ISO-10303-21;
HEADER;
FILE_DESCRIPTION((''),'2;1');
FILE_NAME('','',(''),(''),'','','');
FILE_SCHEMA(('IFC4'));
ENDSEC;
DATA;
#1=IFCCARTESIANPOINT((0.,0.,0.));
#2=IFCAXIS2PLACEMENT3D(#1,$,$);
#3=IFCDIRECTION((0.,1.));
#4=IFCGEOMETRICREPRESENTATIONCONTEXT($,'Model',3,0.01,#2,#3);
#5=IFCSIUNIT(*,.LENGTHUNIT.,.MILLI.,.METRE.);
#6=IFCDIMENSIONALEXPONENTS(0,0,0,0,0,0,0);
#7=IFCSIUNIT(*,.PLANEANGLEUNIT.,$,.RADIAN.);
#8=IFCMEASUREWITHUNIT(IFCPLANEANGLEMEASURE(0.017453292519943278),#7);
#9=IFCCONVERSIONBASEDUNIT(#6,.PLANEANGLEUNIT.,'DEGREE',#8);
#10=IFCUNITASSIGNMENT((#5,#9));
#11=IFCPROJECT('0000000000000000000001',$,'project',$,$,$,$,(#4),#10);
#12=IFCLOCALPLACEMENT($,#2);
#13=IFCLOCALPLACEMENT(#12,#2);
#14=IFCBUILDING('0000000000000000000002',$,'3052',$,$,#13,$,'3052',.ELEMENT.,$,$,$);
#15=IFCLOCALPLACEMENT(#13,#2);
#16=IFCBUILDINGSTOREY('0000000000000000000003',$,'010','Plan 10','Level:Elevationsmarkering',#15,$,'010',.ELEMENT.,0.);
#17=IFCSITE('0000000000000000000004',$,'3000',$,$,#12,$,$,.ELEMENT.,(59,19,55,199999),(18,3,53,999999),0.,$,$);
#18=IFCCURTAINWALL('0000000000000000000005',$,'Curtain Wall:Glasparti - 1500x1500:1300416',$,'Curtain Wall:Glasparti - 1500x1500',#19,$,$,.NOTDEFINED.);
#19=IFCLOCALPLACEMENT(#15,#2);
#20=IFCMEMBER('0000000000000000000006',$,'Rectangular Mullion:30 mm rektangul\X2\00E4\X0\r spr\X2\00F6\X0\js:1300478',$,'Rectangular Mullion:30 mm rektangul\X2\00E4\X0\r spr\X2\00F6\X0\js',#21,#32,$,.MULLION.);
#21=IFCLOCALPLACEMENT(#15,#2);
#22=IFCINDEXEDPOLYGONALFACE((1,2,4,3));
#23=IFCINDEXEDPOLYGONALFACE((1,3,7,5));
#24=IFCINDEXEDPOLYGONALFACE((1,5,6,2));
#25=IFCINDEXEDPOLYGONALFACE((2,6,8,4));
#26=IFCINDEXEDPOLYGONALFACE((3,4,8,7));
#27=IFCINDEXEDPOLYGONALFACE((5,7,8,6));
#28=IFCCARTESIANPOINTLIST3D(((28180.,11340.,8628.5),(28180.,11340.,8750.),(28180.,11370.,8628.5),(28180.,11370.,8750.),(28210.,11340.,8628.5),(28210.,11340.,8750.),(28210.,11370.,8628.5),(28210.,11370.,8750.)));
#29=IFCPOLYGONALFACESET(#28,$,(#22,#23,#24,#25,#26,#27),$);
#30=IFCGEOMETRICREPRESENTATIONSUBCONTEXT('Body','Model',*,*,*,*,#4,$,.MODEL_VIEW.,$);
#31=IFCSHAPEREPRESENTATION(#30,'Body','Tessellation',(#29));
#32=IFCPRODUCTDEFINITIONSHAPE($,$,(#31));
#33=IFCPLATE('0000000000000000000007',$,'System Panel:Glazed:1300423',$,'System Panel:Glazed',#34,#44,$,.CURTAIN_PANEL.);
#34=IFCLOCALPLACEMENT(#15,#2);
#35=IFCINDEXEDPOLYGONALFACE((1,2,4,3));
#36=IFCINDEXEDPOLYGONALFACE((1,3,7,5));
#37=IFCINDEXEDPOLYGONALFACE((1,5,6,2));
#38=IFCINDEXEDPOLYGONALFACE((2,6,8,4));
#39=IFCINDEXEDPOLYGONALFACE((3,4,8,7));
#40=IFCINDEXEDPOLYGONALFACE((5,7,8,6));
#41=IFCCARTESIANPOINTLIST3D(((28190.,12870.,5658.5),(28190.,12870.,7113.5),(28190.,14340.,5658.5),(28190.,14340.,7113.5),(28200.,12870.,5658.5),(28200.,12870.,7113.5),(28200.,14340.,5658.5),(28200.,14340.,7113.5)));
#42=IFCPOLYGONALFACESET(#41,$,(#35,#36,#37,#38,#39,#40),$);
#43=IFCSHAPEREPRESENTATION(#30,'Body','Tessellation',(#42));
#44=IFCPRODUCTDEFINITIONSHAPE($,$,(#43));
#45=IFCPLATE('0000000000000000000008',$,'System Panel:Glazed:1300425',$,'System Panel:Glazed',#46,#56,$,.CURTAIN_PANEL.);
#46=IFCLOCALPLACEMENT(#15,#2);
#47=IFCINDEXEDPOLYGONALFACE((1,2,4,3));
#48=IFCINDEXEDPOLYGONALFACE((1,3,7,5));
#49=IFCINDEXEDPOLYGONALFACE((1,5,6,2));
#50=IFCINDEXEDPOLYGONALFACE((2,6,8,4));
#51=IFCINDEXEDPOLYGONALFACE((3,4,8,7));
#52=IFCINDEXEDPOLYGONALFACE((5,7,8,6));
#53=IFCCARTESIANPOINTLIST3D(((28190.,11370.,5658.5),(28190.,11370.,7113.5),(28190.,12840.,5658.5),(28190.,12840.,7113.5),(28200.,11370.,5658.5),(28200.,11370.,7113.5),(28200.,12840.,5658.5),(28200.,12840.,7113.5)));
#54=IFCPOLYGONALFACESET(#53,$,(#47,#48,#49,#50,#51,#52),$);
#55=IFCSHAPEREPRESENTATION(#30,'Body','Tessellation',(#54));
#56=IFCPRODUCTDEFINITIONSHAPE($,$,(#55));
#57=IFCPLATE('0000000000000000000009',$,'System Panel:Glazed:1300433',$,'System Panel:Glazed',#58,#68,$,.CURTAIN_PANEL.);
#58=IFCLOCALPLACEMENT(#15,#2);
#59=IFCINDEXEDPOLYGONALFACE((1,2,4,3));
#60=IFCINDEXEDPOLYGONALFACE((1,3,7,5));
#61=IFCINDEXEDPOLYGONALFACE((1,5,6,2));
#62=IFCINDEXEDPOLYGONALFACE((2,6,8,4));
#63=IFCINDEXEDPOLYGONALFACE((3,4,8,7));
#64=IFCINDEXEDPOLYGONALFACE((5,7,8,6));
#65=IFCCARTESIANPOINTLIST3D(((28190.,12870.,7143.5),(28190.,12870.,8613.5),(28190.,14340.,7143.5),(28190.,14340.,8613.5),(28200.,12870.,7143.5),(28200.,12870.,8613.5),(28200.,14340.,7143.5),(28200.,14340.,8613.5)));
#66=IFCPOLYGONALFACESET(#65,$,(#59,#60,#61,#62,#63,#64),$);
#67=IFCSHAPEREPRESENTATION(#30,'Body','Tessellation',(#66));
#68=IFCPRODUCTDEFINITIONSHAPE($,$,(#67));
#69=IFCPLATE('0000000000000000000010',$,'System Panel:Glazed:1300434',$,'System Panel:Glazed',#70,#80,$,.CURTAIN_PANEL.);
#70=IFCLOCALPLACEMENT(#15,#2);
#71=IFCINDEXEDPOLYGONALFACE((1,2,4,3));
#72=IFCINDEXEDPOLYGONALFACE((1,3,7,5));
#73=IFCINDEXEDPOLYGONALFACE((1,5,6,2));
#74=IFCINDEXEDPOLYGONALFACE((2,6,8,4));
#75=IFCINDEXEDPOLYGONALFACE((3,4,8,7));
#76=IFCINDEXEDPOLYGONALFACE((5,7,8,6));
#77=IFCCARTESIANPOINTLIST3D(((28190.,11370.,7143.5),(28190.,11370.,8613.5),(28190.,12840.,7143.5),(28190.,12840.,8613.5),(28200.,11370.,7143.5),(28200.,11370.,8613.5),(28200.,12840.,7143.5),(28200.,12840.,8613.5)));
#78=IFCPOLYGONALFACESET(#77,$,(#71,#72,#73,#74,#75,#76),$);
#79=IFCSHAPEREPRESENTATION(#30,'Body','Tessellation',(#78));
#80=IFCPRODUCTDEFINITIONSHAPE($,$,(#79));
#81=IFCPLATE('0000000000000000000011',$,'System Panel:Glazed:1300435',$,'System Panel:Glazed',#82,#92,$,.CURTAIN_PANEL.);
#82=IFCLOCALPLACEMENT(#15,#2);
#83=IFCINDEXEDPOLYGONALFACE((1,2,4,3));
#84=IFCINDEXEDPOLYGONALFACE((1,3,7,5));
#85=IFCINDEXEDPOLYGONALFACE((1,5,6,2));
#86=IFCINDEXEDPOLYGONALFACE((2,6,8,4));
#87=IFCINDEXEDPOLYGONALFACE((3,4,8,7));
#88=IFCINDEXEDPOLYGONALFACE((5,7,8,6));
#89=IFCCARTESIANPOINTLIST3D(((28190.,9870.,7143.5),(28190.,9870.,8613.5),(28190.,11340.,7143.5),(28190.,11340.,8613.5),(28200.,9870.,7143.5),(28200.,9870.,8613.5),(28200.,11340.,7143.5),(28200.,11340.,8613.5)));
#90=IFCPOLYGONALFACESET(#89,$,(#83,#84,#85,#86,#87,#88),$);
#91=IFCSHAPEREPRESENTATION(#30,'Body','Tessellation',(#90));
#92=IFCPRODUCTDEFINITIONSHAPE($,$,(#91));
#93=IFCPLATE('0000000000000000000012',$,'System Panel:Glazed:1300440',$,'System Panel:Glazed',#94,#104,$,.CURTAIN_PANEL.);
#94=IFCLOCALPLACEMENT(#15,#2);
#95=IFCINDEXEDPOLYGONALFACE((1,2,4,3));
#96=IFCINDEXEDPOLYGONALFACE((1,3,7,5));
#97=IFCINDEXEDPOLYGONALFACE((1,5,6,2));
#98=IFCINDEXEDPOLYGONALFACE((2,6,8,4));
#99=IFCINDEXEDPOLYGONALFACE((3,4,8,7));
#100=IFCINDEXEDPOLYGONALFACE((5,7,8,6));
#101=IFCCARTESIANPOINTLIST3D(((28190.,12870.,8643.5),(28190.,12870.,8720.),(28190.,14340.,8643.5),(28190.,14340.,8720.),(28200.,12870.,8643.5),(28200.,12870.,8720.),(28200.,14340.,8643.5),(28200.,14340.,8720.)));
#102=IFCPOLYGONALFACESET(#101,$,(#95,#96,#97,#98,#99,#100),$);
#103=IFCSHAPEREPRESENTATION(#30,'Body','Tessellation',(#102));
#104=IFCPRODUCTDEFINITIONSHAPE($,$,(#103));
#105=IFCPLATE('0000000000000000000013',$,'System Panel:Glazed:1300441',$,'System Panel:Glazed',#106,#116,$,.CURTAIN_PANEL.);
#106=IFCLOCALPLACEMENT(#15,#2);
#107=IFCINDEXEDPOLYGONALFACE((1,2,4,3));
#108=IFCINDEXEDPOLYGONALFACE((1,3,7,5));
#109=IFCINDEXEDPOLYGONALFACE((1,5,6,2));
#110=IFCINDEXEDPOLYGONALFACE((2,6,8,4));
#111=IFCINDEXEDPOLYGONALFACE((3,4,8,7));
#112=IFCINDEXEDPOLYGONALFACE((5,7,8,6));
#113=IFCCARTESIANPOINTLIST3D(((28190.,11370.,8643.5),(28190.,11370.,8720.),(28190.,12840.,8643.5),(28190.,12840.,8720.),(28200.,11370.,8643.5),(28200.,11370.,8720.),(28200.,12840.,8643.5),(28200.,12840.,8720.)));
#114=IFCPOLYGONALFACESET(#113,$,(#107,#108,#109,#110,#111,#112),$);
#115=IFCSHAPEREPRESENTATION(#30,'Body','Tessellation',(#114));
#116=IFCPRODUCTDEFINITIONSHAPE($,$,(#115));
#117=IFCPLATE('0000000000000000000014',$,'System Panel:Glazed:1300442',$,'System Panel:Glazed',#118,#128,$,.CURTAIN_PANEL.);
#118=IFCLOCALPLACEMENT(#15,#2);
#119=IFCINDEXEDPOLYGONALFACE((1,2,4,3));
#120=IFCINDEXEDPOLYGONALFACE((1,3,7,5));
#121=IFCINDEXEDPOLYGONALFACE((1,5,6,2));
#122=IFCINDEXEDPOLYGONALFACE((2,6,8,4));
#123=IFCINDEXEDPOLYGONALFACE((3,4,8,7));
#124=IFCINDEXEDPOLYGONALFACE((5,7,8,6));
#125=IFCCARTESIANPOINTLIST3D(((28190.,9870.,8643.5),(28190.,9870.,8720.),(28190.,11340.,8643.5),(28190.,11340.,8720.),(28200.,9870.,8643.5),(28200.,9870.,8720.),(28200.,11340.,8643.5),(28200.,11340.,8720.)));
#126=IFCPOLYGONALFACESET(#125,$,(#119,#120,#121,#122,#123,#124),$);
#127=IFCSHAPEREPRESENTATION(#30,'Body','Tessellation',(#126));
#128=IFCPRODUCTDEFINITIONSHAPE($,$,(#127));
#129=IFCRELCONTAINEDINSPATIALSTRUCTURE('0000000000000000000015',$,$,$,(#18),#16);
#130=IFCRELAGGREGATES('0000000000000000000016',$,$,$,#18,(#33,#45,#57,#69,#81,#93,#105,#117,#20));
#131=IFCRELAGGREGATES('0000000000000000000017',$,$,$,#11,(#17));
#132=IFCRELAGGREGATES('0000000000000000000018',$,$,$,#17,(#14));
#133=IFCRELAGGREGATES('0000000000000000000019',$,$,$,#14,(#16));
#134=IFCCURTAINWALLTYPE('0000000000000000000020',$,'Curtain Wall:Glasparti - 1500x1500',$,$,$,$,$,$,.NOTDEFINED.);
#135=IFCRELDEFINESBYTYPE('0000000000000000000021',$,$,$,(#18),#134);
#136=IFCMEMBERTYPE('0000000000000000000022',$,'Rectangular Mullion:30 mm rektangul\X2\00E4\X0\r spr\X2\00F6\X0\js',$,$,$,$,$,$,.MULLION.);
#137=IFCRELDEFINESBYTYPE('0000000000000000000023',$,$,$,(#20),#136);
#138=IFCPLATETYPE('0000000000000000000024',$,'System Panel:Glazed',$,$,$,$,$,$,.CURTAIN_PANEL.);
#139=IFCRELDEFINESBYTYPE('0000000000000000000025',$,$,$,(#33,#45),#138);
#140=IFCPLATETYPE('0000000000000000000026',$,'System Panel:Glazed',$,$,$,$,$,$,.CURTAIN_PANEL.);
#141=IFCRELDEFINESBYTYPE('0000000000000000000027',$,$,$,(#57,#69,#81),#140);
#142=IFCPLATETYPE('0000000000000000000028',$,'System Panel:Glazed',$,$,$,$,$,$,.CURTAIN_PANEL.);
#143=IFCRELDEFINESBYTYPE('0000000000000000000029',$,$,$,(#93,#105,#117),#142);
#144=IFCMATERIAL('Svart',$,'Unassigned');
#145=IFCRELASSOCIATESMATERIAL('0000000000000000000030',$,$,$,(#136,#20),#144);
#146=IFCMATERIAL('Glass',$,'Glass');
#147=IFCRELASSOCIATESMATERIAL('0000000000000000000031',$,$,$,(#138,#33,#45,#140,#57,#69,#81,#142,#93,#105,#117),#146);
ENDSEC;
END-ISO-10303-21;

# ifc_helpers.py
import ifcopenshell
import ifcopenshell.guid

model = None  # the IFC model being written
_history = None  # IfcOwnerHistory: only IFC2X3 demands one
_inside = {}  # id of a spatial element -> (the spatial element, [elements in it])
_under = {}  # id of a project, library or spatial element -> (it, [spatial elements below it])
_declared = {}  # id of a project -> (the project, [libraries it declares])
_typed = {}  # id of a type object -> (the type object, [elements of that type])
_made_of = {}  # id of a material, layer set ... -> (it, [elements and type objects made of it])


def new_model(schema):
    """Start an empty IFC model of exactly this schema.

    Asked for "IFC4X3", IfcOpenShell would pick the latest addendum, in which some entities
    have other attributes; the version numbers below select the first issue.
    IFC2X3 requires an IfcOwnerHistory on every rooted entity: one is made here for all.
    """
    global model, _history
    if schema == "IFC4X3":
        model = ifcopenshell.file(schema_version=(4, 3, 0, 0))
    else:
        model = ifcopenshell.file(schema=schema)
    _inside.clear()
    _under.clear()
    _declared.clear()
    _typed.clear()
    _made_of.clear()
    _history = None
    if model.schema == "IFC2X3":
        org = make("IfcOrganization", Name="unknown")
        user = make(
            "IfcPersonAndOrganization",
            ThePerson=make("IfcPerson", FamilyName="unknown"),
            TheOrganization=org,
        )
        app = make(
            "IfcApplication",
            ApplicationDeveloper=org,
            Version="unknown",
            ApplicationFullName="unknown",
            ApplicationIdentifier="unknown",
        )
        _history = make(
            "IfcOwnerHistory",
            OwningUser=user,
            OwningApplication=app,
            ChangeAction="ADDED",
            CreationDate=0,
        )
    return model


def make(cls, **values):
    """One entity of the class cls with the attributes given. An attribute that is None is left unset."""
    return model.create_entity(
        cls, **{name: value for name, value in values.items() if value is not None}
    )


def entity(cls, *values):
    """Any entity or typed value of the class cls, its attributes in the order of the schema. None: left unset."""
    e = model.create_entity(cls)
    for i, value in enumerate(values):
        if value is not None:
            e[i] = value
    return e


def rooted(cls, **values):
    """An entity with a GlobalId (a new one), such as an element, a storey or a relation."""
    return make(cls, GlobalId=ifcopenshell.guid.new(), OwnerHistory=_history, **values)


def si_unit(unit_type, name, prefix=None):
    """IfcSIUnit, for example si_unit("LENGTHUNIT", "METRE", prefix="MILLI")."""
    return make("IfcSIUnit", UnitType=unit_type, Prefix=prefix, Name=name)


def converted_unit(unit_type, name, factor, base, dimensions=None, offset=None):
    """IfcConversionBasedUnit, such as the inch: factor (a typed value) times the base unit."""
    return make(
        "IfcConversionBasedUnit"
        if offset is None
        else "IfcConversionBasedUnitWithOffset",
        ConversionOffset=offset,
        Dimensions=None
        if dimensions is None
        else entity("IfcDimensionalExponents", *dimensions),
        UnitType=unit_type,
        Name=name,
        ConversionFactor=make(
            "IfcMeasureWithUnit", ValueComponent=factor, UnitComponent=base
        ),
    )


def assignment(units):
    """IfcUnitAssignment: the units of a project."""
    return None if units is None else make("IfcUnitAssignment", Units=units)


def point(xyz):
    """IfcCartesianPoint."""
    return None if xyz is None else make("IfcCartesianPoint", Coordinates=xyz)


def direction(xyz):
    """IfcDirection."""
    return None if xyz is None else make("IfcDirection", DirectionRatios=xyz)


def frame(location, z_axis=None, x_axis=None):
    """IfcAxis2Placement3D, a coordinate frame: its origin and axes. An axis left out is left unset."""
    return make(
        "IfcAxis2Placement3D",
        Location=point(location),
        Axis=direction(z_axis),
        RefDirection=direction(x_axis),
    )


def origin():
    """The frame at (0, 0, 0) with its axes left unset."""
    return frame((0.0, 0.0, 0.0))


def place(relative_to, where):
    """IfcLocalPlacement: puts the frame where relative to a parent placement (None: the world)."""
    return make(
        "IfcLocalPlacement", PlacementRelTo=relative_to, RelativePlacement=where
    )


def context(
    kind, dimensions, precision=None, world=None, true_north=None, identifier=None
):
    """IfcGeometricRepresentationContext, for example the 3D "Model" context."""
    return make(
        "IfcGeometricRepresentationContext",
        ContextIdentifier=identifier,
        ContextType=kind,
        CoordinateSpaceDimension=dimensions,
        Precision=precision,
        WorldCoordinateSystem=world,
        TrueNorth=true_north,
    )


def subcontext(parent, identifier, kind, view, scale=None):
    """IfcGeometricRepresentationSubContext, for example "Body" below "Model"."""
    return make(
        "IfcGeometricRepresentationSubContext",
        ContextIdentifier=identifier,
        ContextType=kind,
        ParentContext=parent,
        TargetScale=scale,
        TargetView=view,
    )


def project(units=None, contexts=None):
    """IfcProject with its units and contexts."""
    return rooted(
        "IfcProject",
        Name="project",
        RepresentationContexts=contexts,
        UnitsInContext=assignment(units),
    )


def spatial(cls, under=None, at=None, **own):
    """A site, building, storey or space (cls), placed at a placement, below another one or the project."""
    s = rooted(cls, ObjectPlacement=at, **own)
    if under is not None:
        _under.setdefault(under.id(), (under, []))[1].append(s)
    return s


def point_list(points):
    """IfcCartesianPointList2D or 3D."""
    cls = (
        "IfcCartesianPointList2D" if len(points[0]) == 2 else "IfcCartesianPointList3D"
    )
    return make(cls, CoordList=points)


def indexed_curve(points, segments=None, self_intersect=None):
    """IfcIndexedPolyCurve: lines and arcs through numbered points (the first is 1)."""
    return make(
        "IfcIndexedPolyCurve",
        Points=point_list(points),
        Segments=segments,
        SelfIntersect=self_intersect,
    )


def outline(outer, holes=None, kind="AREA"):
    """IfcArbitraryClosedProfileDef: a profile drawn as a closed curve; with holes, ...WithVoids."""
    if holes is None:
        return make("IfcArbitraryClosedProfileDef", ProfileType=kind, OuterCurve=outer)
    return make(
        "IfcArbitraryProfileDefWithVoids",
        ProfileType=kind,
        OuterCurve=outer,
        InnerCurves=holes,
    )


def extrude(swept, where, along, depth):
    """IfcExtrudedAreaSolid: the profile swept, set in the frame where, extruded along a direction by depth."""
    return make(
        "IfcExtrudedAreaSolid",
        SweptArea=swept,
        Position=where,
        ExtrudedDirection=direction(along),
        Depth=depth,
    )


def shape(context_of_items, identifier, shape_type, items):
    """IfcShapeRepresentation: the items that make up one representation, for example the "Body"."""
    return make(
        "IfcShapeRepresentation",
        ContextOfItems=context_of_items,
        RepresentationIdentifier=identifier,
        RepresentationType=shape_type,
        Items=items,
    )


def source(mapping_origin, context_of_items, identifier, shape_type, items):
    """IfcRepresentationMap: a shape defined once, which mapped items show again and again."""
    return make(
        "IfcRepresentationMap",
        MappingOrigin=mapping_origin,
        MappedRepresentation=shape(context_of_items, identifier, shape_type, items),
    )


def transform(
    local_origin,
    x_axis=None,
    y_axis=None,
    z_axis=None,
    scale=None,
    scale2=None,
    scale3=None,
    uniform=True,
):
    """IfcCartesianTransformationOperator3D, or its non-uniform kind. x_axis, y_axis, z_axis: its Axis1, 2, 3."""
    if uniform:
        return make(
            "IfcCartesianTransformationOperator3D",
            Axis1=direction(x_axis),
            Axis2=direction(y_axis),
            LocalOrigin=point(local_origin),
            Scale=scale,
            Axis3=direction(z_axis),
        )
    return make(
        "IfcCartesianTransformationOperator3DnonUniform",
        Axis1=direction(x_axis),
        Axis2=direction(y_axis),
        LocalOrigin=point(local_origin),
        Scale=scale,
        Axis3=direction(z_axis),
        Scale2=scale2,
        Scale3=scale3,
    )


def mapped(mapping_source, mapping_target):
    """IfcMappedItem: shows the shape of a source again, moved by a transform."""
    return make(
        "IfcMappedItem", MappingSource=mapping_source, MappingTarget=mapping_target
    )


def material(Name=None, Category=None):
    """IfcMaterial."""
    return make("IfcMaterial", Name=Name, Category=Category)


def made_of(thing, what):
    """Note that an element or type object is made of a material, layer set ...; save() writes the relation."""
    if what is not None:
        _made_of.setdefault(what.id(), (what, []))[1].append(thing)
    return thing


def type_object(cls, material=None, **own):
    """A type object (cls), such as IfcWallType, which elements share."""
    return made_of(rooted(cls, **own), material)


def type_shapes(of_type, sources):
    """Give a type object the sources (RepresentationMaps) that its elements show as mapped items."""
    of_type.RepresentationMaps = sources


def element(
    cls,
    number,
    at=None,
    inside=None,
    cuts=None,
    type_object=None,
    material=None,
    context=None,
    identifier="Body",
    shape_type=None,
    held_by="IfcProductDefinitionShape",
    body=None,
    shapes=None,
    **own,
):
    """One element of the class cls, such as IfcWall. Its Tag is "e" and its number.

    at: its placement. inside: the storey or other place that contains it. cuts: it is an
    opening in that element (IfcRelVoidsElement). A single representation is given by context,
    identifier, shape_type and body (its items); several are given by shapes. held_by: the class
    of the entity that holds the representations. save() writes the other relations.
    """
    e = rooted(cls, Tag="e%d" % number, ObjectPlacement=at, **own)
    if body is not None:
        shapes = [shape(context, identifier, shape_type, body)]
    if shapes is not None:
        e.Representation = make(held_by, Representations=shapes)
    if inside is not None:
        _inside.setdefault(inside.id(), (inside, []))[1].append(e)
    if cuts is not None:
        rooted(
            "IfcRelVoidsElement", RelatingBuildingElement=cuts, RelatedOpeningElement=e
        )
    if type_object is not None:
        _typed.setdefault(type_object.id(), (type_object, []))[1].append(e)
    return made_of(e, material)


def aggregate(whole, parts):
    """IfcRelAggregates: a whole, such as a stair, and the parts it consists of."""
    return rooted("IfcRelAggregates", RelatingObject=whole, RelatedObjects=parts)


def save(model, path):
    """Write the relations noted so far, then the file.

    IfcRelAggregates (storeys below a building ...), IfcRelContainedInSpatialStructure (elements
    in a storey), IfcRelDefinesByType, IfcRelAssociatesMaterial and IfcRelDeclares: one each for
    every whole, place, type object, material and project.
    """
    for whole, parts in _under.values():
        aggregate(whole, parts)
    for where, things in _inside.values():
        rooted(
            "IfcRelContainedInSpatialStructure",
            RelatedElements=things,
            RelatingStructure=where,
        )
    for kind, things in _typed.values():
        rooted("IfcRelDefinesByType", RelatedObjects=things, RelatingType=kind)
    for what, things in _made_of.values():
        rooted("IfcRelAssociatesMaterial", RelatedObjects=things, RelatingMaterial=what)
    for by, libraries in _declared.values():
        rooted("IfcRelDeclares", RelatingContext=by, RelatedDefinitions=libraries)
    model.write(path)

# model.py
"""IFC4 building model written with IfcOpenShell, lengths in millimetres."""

from ifc_helpers import new_model, entity, si_unit, converted_unit, direction, frame, origin, place, context, subcontext, project, spatial, indexed_curve, outline, extrude, source, transform, mapped, material, type_object, type_shapes, element, aggregate, save


model = new_model("IFC4")

# Units and contexts
model_context = context("Model", 3, precision=0.01, world=origin(), true_north=direction((0.0, 1.0)))
body_context = subcontext(model_context, "Body", "Model", "MODEL_VIEW")
ifc_project = project(units=[si_unit("LENGTHUNIT", "METRE", prefix="MILLI"), converted_unit("PLANEANGLEUNIT", "DEGREE", entity("IfcPlaneAngleMeasure", 0.017453292519943278), si_unit("PLANEANGLEUNIT", "RADIAN"), dimensions=[0, 0, 0, 0, 0, 0, 0])], contexts=[model_context])

# Site, building, storey
site_placement = place(None, origin())
site = spatial("IfcSite", under=ifc_project, at=site_placement, Name="3000", CompositionType="ELEMENT", RefLatitude=(59, 19, 55, 199999), RefLongitude=(18, 3, 53, 999999), RefElevation=0.0)
building_placement = place(site_placement, origin())
building = spatial("IfcBuilding", under=site, at=building_placement, Name="3052", LongName="3052", CompositionType="ELEMENT")
storey_placement = place(building_placement, origin())
storey = spatial("IfcBuildingStorey", under=building, at=storey_placement, Name="010", Description="Plan 10", ObjectType="Level:Elevationsmarkering", LongName="010", CompositionType="ELEMENT", Elevation=0.0)

# Curtain wall, member, plates
curtain_wall_type = type_object("IfcCurtainWallType", Name="Curtain Wall:Glasparti - 1500x1500", PredefinedType="NOTDEFINED")
curtain_wall_placement = place(storey_placement, origin())
curtain_wall = element("IfcCurtainWall", 1, at=curtain_wall_placement, inside=storey, type_object=curtain_wall_type, Name="Curtain Wall:Glasparti - 1500x1500:1300416", ObjectType="Curtain Wall:Glasparti - 1500x1500", PredefinedType="NOTDEFINED")
ifc_material_1 = material(Name="Svart", Category="Unassigned")
member_type_1 = type_object("IfcMemberType", Name="Rectangular Mullion:30 mm rektangulär spröjs", PredefinedType="MULLION", material=ifc_material_1)
shared_shape_1 = source(origin(), body_context, "Body", "SweptSolid", [
    extrude(outline(indexed_curve([(-15.0, -15.0), (15.0, -15.0), (15.0, 15.0), (-15.0, 15.0), (-15.0, -15.0)], self_intersect=False)), frame((0.0, 0.0, -121.5), z_axis=(0.0, 0.0, 1.0), x_axis=(-1.0, 0.0, 0.0)), (0.0, 0.0, 1.0), 121.5),
])
type_shapes(member_type_1, [shared_shape_1])
member_1_placement = place(curtain_wall_placement, frame((28195.0, 11355.0, 8628.5), z_axis=(0.0, 0.0, -1.0), x_axis=(0.0, -1.0, 0.0)))
member_1 = element("IfcMember", 2, at=member_1_placement, type_object=member_type_1, material=ifc_material_1, Name="Rectangular Mullion:30 mm rektangulär spröjs:1300478", ObjectType="Rectangular Mullion:30 mm rektangulär spröjs", PredefinedType="MULLION", context=body_context, shape_type="MappedRepresentation", body=[
    mapped(shared_shape_1, transform((0.0, 0.0, 0.0), scale=1.0)),
])
ifc_material_2 = material(Name="Glass", Category="Glass")
plate_type_1 = type_object("IfcPlateType", Name="System Panel:Glazed", PredefinedType="CURTAIN_PANEL", material=ifc_material_2)
shared_shape_2 = source(origin(), body_context, "Body", "SweptSolid", [
    extrude(outline(indexed_curve([(-5.0, -735.0), (5.0, -735.0), (5.0, 735.0), (-5.0, 735.0), (-5.0, -735.0)], self_intersect=False)), frame((0.0, 0.0, 0.0), z_axis=(0.0, 0.0, 1.0), x_axis=(0.0, 1.0, 0.0)), (0.0, 0.0, 1.0), 1455.0),
])
type_shapes(plate_type_1, [shared_shape_2])
plate_1_placement = place(curtain_wall_placement, frame((28195.0, 13605.0, 5658.5), z_axis=(0.0, 0.0, 1.0), x_axis=(0.0, -1.0, 0.0)))
plate_1 = element("IfcPlate", 3, at=plate_1_placement, type_object=plate_type_1, material=ifc_material_2, Name="System Panel:Glazed:1300423", ObjectType="System Panel:Glazed", PredefinedType="CURTAIN_PANEL", context=body_context, shape_type="MappedRepresentation", body=[
    mapped(shared_shape_2, transform((0.0, 0.0, 0.0), scale=1.0)),
])
plate_2_placement = place(curtain_wall_placement, frame((28195.0, 12105.0, 5658.5), z_axis=(0.0, 0.0, 1.0), x_axis=(0.0, -1.0, 0.0)))
plate_2 = element("IfcPlate", 4, at=plate_2_placement, type_object=plate_type_1, material=ifc_material_2, Name="System Panel:Glazed:1300425", ObjectType="System Panel:Glazed", PredefinedType="CURTAIN_PANEL", context=body_context, shape_type="MappedRepresentation", body=[
    mapped(shared_shape_2, transform((0.0, 0.0, 0.0), scale=1.0)),
])
plate_type_2 = type_object("IfcPlateType", Name="System Panel:Glazed", PredefinedType="CURTAIN_PANEL", material=ifc_material_2)
shared_shape_3 = source(origin(), body_context, "Body", "SweptSolid", [
    extrude(outline(indexed_curve([(-5.0, -735.0), (5.0, -735.0), (5.0, 735.0), (-5.0, 735.0), (-5.0, -735.0)], self_intersect=False)), frame((0.0, 0.0, 0.0), z_axis=(0.0, 0.0, 1.0), x_axis=(0.0, 1.0, 0.0)), (0.0, 0.0, 1.0), 1470.0),
])
type_shapes(plate_type_2, [shared_shape_3])
plate_3_placement = place(curtain_wall_placement, frame((28195.0, 13605.0, 7143.5), z_axis=(0.0, 0.0, 1.0), x_axis=(0.0, -1.0, 0.0)))
plate_3 = element("IfcPlate", 5, at=plate_3_placement, type_object=plate_type_2, material=ifc_material_2, Name="System Panel:Glazed:1300433", ObjectType="System Panel:Glazed", PredefinedType="CURTAIN_PANEL", context=body_context, shape_type="MappedRepresentation", body=[
    mapped(shared_shape_3, transform((0.0, 0.0, 0.0), scale=1.0)),
])
plate_4_placement = place(curtain_wall_placement, frame((28195.0, 12105.0, 7143.5), z_axis=(0.0, 0.0, 1.0), x_axis=(0.0, -1.0, 0.0)))
plate_4 = element("IfcPlate", 6, at=plate_4_placement, type_object=plate_type_2, material=ifc_material_2, Name="System Panel:Glazed:1300434", ObjectType="System Panel:Glazed", PredefinedType="CURTAIN_PANEL", context=body_context, shape_type="MappedRepresentation", body=[
    mapped(shared_shape_3, transform((0.0, 0.0, 0.0), scale=1.0)),
])
plate_5_placement = place(curtain_wall_placement, frame((28195.0, 10605.0, 7143.5), z_axis=(0.0, 0.0, 1.0), x_axis=(0.0, -1.0, 0.0)))
plate_5 = element("IfcPlate", 7, at=plate_5_placement, type_object=plate_type_2, material=ifc_material_2, Name="System Panel:Glazed:1300435", ObjectType="System Panel:Glazed", PredefinedType="CURTAIN_PANEL", context=body_context, shape_type="MappedRepresentation", body=[
    mapped(shared_shape_3, transform((0.0, 0.0, 0.0), scale=1.0)),
])
plate_type_3 = type_object("IfcPlateType", Name="System Panel:Glazed", PredefinedType="CURTAIN_PANEL", material=ifc_material_2)
shared_shape_4 = source(origin(), body_context, "Body", "SweptSolid", [
    extrude(outline(indexed_curve([(-5.0, -735.0), (5.0, -735.0), (5.0, 735.0), (-5.0, 735.0), (-5.0, -735.0)], self_intersect=False)), frame((0.0, 0.0, 0.0), z_axis=(0.0, 0.0, 1.0), x_axis=(0.0, 1.0, 0.0)), (0.0, 0.0, 1.0), 76.5),
])
type_shapes(plate_type_3, [shared_shape_4])
plate_6_placement = place(curtain_wall_placement, frame((28195.0, 13605.0, 8643.5), z_axis=(0.0, 0.0, 1.0), x_axis=(0.0, -1.0, 0.0)))
plate_6 = element("IfcPlate", 8, at=plate_6_placement, type_object=plate_type_3, material=ifc_material_2, Name="System Panel:Glazed:1300440", ObjectType="System Panel:Glazed", PredefinedType="CURTAIN_PANEL", context=body_context, shape_type="MappedRepresentation", body=[
    mapped(shared_shape_4, transform((0.0, 0.0, 0.0), scale=1.0)),
])
plate_7_placement = place(curtain_wall_placement, frame((28195.0, 12105.0, 8643.5), z_axis=(0.0, 0.0, 1.0), x_axis=(0.0, -1.0, 0.0)))
plate_7 = element("IfcPlate", 9, at=plate_7_placement, type_object=plate_type_3, material=ifc_material_2, Name="System Panel:Glazed:1300441", ObjectType="System Panel:Glazed", PredefinedType="CURTAIN_PANEL", context=body_context, shape_type="MappedRepresentation", body=[
    mapped(shared_shape_4, transform((0.0, 0.0, 0.0), scale=1.0)),
])
plate_8_placement = place(curtain_wall_placement, frame((28195.0, 10605.0, 8643.5), z_axis=(0.0, 0.0, 1.0), x_axis=(0.0, -1.0, 0.0)))
plate_8 = element("IfcPlate", 10, at=plate_8_placement, type_object=plate_type_3, material=ifc_material_2, Name="System Panel:Glazed:1300442", ObjectType="System Panel:Glazed", PredefinedType="CURTAIN_PANEL", context=body_context, shape_type="MappedRepresentation", body=[
    mapped(shared_shape_4, transform((0.0, 0.0, 0.0), scale=1.0)),
])
aggregate(curtain_wall, [plate_1, plate_2, plate_3, plate_4, plate_5, plate_6, plate_7, plate_8, member_1])

save(model, "model.ifc")
